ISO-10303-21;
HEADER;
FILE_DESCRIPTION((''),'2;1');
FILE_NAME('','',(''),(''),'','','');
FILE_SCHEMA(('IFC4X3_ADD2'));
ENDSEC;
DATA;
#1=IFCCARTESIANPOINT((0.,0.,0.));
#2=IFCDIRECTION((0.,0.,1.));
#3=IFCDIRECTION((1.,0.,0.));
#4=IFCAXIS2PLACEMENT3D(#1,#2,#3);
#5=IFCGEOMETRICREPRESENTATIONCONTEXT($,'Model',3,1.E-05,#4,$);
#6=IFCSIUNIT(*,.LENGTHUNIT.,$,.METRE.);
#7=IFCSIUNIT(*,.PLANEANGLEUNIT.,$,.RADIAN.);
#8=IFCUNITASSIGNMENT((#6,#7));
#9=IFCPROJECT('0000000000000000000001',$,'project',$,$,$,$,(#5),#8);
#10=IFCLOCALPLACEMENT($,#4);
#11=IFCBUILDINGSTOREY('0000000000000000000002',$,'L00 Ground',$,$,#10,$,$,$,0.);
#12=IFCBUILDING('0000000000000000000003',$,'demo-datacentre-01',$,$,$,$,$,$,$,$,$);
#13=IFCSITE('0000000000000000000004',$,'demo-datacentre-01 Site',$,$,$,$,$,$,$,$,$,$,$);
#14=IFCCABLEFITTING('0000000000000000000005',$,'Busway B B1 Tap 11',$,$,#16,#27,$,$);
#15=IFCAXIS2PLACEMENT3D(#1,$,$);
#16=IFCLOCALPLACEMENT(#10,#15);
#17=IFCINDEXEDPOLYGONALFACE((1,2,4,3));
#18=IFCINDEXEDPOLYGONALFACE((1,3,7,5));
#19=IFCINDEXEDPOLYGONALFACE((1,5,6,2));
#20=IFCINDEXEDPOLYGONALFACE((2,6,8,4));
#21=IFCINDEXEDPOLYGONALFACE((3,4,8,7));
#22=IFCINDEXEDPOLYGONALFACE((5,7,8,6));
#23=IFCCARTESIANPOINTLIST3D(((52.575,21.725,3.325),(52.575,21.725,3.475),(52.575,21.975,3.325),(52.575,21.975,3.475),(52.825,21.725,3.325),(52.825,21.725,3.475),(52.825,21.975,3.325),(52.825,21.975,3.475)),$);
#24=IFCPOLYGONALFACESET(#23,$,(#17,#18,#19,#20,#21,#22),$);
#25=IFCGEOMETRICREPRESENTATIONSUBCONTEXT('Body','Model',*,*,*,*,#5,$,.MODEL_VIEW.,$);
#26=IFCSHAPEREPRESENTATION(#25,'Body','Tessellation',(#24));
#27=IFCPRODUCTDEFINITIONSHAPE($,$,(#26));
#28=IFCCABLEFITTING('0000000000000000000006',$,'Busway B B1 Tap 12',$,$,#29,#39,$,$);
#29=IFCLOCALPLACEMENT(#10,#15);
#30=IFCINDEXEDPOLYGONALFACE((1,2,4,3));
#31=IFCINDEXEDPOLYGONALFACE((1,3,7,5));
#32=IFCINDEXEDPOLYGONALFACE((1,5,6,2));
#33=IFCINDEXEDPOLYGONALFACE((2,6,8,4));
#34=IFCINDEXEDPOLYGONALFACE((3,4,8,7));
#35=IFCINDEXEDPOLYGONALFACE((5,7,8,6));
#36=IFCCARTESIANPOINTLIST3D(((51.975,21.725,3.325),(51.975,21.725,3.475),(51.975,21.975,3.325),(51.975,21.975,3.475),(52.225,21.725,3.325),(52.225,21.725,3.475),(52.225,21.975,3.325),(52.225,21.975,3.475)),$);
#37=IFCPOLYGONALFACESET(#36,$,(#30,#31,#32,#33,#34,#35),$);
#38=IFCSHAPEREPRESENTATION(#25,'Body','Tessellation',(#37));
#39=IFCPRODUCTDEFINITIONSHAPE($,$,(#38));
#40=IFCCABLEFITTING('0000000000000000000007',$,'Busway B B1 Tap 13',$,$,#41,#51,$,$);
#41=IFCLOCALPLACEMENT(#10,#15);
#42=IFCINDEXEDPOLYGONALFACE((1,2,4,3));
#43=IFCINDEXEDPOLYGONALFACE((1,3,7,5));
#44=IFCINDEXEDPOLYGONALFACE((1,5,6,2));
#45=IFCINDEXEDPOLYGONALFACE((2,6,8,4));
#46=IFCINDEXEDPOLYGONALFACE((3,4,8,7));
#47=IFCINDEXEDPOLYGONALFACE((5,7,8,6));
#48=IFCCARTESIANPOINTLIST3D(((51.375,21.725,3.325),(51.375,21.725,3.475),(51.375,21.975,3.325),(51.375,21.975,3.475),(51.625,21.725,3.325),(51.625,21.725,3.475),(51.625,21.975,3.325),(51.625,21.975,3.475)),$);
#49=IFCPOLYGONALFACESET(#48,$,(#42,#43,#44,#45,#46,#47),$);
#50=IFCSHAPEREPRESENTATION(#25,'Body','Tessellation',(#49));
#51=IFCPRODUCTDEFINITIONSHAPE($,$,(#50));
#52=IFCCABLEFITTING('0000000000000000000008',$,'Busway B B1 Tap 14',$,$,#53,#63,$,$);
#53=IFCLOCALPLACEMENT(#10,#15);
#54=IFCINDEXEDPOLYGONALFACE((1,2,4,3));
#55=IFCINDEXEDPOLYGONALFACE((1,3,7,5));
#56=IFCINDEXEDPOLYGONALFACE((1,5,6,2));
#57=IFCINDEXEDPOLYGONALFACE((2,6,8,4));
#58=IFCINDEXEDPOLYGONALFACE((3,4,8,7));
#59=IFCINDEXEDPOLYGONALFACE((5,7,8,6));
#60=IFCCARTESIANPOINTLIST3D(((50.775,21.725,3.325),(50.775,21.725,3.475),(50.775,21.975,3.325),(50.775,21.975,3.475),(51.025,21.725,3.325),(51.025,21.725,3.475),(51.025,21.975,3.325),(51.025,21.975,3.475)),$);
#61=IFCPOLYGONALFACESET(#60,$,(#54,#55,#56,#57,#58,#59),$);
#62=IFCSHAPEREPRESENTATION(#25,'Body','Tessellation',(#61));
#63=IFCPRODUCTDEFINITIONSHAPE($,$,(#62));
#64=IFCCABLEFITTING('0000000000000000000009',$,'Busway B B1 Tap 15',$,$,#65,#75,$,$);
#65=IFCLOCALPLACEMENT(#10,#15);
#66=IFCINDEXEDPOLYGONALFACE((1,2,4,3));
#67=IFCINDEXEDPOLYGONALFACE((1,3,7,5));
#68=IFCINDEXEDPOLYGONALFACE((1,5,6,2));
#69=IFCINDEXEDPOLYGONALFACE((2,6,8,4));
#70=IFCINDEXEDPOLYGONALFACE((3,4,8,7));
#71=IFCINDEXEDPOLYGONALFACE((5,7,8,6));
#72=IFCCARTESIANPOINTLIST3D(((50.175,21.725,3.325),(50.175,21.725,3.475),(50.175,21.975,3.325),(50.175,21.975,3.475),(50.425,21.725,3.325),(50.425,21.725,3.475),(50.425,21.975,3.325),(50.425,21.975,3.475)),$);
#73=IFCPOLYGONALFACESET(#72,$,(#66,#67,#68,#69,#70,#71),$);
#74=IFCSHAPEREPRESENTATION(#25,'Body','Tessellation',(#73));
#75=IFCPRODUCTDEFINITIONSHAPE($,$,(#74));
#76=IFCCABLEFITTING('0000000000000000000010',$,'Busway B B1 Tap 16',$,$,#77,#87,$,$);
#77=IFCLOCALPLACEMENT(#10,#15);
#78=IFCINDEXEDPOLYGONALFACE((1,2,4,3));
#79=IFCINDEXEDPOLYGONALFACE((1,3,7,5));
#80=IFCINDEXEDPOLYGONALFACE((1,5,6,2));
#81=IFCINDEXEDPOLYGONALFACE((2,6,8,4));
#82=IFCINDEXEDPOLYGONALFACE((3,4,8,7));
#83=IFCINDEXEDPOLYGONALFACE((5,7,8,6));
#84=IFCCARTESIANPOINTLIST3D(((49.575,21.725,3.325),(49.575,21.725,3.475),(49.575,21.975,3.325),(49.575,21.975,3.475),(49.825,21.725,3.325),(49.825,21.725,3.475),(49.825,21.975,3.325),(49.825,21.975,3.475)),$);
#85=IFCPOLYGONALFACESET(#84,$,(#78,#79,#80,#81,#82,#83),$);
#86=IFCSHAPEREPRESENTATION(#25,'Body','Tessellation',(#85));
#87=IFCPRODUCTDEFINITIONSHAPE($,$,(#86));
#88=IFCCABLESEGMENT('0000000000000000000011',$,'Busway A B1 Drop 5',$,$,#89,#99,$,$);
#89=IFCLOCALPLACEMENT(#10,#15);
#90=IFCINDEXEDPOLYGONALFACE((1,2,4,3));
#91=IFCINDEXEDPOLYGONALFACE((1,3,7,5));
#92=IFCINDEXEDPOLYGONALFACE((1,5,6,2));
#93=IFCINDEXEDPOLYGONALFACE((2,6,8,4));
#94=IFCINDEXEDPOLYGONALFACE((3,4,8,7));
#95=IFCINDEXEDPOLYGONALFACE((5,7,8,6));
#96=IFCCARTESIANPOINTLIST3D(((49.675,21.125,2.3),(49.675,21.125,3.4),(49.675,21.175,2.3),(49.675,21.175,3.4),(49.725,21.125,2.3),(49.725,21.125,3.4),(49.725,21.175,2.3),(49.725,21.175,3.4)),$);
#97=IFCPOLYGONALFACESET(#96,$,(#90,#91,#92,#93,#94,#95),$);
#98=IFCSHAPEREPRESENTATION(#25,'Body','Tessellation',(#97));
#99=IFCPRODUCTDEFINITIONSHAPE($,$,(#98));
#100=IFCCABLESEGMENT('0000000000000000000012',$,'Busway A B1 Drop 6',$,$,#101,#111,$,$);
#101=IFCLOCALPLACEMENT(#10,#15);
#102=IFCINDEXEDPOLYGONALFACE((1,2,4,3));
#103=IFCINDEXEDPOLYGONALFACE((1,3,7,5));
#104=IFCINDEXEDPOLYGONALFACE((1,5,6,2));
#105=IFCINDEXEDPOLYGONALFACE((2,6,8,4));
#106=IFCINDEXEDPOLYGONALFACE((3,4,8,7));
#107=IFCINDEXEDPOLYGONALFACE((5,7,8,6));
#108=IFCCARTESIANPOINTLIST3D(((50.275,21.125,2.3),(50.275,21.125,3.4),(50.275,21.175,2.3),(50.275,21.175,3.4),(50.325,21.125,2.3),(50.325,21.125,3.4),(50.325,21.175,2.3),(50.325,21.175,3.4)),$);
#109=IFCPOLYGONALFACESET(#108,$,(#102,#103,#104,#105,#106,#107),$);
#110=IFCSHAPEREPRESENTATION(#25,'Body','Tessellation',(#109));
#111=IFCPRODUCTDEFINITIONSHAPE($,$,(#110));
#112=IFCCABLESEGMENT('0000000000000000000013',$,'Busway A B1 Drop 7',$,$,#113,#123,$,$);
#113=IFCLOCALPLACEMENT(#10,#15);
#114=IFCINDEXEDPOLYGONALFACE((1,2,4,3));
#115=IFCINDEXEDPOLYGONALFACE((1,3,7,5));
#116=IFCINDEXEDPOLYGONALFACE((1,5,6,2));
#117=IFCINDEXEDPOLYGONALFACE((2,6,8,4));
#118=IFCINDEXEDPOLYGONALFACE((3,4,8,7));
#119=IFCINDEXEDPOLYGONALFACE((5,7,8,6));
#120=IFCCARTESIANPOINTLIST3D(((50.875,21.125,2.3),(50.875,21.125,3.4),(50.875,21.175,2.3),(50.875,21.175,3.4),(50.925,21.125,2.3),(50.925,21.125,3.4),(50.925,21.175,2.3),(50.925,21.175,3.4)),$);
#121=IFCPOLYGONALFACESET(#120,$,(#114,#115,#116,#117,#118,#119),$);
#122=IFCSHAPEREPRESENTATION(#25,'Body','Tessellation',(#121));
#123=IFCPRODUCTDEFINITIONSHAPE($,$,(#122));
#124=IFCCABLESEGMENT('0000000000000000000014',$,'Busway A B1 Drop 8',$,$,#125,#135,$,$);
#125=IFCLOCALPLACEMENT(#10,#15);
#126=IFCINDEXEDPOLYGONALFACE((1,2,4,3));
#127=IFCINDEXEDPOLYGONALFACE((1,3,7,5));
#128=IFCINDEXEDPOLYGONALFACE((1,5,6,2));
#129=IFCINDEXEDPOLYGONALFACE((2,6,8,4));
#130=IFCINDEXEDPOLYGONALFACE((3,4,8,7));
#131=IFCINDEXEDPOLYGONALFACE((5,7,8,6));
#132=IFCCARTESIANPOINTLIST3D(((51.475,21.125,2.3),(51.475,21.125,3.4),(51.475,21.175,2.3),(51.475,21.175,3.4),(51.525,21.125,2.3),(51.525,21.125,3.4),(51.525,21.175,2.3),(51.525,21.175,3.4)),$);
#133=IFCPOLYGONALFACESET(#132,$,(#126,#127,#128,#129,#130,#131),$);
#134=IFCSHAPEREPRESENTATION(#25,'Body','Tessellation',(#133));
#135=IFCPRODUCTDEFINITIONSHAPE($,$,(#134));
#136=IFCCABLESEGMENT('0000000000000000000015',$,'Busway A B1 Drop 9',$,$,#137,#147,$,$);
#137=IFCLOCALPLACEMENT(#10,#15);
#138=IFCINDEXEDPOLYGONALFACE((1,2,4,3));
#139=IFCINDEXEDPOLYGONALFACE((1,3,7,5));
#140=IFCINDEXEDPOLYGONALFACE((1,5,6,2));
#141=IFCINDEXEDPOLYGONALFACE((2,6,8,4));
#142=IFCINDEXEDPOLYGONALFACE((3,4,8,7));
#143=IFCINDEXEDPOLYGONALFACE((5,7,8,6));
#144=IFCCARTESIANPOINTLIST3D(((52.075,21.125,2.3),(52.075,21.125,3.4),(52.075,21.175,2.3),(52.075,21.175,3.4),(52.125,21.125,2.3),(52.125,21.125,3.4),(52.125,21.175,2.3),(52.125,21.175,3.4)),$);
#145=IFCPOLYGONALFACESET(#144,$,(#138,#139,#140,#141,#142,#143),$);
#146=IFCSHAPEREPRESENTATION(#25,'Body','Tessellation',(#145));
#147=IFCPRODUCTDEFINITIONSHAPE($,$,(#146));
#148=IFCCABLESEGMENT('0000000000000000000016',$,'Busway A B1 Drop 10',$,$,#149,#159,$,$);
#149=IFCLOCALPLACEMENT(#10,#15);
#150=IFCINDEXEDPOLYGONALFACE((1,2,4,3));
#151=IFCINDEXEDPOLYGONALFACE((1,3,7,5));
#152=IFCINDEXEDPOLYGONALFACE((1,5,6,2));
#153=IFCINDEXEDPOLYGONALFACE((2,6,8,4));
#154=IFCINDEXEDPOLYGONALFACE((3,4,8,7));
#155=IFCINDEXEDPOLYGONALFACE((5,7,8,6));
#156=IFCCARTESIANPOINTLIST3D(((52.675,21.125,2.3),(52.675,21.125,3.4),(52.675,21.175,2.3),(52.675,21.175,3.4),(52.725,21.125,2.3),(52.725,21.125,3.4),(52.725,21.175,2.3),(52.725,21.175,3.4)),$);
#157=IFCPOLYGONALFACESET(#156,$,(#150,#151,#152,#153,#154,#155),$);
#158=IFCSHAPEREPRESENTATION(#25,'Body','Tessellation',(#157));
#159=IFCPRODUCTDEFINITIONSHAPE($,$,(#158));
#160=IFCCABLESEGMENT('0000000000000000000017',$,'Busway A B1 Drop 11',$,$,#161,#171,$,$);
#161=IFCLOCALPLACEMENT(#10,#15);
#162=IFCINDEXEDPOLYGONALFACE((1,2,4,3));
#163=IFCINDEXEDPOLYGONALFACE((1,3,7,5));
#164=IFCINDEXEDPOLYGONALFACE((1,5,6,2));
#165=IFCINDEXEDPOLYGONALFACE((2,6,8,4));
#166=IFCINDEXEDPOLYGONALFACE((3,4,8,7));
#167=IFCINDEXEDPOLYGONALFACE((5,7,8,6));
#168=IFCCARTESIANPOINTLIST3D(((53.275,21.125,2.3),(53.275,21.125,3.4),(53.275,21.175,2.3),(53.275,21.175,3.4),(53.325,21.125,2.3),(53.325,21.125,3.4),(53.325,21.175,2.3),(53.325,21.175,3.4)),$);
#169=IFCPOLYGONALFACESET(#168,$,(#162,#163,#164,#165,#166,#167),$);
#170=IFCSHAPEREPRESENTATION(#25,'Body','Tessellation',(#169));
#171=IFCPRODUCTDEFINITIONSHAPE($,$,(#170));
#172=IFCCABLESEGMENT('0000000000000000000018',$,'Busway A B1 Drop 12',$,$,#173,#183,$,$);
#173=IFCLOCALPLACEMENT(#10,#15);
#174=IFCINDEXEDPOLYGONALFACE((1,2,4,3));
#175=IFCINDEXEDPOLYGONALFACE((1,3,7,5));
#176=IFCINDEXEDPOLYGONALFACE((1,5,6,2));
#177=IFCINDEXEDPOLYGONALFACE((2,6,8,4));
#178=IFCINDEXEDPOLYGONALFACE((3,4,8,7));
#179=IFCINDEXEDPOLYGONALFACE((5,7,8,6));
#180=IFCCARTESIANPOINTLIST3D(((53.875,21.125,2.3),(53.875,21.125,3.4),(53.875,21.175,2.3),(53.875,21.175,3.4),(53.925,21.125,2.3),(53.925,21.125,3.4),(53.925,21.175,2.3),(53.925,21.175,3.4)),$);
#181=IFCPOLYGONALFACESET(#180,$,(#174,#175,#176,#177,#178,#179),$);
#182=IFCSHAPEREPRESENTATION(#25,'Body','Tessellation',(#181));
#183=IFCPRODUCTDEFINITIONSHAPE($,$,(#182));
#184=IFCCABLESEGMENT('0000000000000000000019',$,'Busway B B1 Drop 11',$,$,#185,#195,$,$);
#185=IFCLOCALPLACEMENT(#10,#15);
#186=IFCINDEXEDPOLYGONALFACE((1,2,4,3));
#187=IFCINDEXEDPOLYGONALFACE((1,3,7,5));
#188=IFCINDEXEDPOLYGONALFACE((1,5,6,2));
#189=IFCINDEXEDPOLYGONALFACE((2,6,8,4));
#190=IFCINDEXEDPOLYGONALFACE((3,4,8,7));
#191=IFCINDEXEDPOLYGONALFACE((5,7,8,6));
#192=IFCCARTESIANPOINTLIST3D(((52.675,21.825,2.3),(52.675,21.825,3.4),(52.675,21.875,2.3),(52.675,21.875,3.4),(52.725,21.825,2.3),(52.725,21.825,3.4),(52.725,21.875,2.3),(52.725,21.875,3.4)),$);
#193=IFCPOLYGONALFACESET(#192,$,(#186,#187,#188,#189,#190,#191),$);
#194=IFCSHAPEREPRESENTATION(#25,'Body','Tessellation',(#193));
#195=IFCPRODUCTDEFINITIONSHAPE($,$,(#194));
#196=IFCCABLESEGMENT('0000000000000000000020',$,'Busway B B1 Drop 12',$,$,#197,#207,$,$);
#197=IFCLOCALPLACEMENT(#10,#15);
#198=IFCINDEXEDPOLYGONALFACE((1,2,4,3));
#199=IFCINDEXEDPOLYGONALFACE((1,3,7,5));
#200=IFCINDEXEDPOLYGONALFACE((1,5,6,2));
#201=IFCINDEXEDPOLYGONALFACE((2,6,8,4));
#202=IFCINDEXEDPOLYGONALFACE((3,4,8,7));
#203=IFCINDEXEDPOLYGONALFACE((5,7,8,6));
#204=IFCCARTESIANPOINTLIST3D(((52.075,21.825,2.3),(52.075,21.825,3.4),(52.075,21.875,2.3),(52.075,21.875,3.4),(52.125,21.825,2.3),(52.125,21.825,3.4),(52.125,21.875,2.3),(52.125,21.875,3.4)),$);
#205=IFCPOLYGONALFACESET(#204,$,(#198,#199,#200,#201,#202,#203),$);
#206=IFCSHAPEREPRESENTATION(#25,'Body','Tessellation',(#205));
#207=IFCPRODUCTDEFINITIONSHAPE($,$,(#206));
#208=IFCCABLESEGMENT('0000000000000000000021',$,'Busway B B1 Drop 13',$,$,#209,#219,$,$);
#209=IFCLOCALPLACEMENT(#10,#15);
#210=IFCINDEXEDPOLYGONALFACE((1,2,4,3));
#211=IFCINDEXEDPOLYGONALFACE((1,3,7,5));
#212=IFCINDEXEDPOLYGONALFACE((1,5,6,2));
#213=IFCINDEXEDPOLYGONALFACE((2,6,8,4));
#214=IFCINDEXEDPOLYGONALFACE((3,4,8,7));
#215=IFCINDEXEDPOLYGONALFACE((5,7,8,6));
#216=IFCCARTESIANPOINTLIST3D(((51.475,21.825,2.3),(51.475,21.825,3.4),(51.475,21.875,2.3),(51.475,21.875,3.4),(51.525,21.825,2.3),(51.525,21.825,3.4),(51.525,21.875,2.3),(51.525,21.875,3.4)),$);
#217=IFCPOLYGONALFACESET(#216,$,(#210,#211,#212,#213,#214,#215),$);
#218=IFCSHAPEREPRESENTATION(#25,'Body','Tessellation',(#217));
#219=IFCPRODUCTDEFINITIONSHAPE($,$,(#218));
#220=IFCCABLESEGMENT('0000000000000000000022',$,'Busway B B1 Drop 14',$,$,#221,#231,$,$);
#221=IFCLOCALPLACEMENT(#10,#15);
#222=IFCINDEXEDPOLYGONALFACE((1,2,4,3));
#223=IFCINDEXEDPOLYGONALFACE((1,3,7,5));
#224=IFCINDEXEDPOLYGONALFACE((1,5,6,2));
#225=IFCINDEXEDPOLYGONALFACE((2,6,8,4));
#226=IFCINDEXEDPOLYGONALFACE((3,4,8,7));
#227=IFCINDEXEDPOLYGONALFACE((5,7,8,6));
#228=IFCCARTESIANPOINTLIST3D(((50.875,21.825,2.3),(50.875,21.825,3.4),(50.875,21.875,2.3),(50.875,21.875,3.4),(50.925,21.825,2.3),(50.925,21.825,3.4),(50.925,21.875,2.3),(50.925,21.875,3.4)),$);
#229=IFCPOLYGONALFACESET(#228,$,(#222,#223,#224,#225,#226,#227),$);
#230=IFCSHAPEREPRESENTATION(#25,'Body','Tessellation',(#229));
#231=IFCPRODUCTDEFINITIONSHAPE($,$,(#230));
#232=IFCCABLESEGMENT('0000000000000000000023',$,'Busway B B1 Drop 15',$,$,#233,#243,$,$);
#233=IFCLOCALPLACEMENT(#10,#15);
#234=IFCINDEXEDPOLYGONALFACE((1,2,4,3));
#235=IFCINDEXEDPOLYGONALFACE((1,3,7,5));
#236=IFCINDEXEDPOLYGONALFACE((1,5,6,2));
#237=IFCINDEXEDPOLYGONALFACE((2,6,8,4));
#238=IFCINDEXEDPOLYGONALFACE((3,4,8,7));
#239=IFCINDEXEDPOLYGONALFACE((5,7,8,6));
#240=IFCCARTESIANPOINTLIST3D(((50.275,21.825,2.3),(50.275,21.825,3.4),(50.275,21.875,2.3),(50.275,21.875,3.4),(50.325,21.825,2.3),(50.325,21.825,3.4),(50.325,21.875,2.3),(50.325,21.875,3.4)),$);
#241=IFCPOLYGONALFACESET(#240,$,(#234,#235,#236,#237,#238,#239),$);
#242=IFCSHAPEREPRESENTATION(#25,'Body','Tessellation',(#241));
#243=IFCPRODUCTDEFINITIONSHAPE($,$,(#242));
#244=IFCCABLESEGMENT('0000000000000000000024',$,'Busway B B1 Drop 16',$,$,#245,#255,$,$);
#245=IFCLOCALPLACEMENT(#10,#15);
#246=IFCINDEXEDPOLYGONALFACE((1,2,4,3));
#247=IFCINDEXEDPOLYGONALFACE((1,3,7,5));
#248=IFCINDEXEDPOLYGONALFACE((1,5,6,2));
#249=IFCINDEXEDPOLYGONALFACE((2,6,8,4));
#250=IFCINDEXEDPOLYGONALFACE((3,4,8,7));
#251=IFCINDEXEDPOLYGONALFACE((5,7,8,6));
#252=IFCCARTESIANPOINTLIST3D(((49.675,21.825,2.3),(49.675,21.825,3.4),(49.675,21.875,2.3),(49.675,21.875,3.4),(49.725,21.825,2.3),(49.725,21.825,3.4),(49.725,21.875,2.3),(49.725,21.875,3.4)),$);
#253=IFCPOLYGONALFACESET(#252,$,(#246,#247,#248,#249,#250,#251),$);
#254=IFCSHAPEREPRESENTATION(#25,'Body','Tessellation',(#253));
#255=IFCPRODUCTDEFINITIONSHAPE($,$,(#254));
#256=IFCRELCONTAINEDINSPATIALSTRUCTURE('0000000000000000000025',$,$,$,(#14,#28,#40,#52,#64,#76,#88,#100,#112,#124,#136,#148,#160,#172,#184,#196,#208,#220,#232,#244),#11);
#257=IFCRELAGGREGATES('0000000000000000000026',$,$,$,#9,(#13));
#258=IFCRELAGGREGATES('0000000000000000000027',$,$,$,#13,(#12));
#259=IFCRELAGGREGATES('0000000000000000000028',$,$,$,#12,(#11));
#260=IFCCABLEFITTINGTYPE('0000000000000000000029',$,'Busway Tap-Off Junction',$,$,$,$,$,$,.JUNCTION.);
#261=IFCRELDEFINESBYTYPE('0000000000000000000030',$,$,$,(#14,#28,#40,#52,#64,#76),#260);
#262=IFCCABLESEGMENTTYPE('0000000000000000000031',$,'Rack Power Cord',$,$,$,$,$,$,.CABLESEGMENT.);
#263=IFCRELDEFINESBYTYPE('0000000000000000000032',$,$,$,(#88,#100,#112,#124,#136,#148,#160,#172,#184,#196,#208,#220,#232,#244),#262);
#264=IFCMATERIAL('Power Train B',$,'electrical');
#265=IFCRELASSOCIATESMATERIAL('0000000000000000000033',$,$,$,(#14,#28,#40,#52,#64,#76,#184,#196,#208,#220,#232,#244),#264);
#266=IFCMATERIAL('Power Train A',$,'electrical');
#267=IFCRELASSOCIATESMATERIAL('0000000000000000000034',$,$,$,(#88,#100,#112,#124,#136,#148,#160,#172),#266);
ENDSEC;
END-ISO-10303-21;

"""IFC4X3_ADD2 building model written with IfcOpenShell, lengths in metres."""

from ifc_helpers import new_model, si_unit, frame, origin_with_axes, place, context, subcontext, project, spatial, rectangle, extrude, material, type_object, element, save


model = new_model("IFC4X3_ADD2")

# Units and contexts
model_context = context("Model", 3, precision=1e-05, world=origin_with_axes())
body_context = subcontext(model_context, "Body", "Model", "MODEL_VIEW")
ifc_project = project(units=[si_unit("LENGTHUNIT", "METRE"), si_unit("PLANEANGLEUNIT", "RADIAN")], contexts=[model_context])

# Site, building, storey
site = spatial("IfcSite", under=ifc_project, Name="demo-datacentre-01 Site")
building = spatial("IfcBuilding", under=site, Name="demo-datacentre-01")
storey_placement = place(None, origin_with_axes())
storey = spatial("IfcBuildingStorey", under=building, at=storey_placement, Name="L00 Ground", Elevation=0.0)

# Shared definitions
ifc_material_1 = material(Name="Power Train A", Category="electrical")
ifc_material_2 = material(Name="Power Train B", Category="electrical")

# Cable fittings
cable_fitting_type = type_object("IfcCableFittingType", Name="Busway Tap-Off Junction", PredefinedType="JUNCTION")
for number, where, z_axis, x_axis, name in (
    (1, (52.7, 21.85, 3.325), (0.0, 0.0, 1.0), (1.0, 0.0, 0.0), "Busway B B1 Tap 11"),
    (2, (52.1, 21.85, 3.325), (0.0, 0.0, 1.0), (1.0, 0.0, 0.0), "Busway B B1 Tap 12"),
    (3, (51.5, 21.85, 3.325), (0.0, 0.0, 1.0), (1.0, 0.0, 0.0), "Busway B B1 Tap 13"),
    (4, (50.9, 21.85, 3.325), (0.0, 0.0, 1.0), (1.0, 0.0, 0.0), "Busway B B1 Tap 14"),
    (5, (50.3, 21.85, 3.325), (0.0, 0.0, 1.0), (1.0, 0.0, 0.0), "Busway B B1 Tap 15"),
    (6, (49.7, 21.85, 3.325), (0.0, 0.0, 1.0), (1.0, 0.0, 0.0), "Busway B B1 Tap 16"),
):
    element("IfcCableFitting", number, at=place(storey_placement, frame(where, z_axis=z_axis, x_axis=x_axis)), inside=storey, type_object=cable_fitting_type, material=ifc_material_2, Name=name, context=body_context, shape_type="SweptSolid", body=[
        extrude(rectangle(XDim=0.25, YDim=0.25), origin_with_axes(), (0.0, 0.0, 1.0), 0.15),
    ])

# Cable segments
cable_segment_type_1 = type_object("IfcCableSegmentType", Name="Rack Power Cord", PredefinedType="CABLESEGMENT")
for number, where, z_axis, x_axis, name in (
    (7, (49.7, 21.15, 3.4), (0.0, 0.0, -1.0), (1.0, 0.0, 0.0), "Busway A B1 Drop 5"),
    (8, (50.3, 21.15, 3.4), (0.0, 0.0, -1.0), (1.0, 0.0, 0.0), "Busway A B1 Drop 6"),
    (9, (50.9, 21.15, 3.4), (0.0, 0.0, -1.0), (1.0, 0.0, 0.0), "Busway A B1 Drop 7"),
    (10, (51.5, 21.15, 3.4), (0.0, 0.0, -1.0), (1.0, 0.0, 0.0), "Busway A B1 Drop 8"),
    (11, (52.1, 21.15, 3.4), (0.0, 0.0, -1.0), (1.0, 0.0, 0.0), "Busway A B1 Drop 9"),
    (12, (52.7, 21.15, 3.4), (0.0, 0.0, -1.0), (1.0, 0.0, 0.0), "Busway A B1 Drop 10"),
    (13, (53.3, 21.15, 3.4), (0.0, 0.0, -1.0), (1.0, 0.0, 0.0), "Busway A B1 Drop 11"),
    (14, (53.9, 21.15, 3.4), (0.0, 0.0, -1.0), (1.0, 0.0, 0.0), "Busway A B1 Drop 12"),
):
    element("IfcCableSegment", number, at=place(storey_placement, frame(where, z_axis=z_axis, x_axis=x_axis)), inside=storey, type_object=cable_segment_type_1, material=ifc_material_1, Name=name, context=body_context, shape_type="SweptSolid", body=[
        extrude(rectangle(XDim=0.05, YDim=0.05), origin_with_axes(), (0.0, 0.0, 1.0), 1.1),
    ])
for number, where, z_axis, x_axis, name in (
    (15, (52.7, 21.85, 3.4), (0.0, 0.0, -1.0), (1.0, 0.0, 0.0), "Busway B B1 Drop 11"),
    (16, (52.1, 21.85, 3.4), (0.0, 0.0, -1.0), (1.0, 0.0, 0.0), "Busway B B1 Drop 12"),
    (17, (51.5, 21.85, 3.4), (0.0, 0.0, -1.0), (1.0, 0.0, 0.0), "Busway B B1 Drop 13"),
    (18, (50.9, 21.85, 3.4), (0.0, 0.0, -1.0), (1.0, 0.0, 0.0), "Busway B B1 Drop 14"),
    (19, (50.3, 21.85, 3.4), (0.0, 0.0, -1.0), (1.0, 0.0, 0.0), "Busway B B1 Drop 15"),
    (20, (49.7, 21.85, 3.4), (0.0, 0.0, -1.0), (1.0, 0.0, 0.0), "Busway B B1 Drop 16"),
):
    element("IfcCableSegment", number, at=place(storey_placement, frame(where, z_axis=z_axis, x_axis=x_axis)), inside=storey, type_object=cable_segment_type_1, material=ifc_material_2, Name=name, context=body_context, shape_type="SweptSolid", body=[
        extrude(rectangle(XDim=0.05, YDim=0.05), origin_with_axes(), (0.0, 0.0, 1.0), 1.1),
    ])

save(model, "model.ifc")
